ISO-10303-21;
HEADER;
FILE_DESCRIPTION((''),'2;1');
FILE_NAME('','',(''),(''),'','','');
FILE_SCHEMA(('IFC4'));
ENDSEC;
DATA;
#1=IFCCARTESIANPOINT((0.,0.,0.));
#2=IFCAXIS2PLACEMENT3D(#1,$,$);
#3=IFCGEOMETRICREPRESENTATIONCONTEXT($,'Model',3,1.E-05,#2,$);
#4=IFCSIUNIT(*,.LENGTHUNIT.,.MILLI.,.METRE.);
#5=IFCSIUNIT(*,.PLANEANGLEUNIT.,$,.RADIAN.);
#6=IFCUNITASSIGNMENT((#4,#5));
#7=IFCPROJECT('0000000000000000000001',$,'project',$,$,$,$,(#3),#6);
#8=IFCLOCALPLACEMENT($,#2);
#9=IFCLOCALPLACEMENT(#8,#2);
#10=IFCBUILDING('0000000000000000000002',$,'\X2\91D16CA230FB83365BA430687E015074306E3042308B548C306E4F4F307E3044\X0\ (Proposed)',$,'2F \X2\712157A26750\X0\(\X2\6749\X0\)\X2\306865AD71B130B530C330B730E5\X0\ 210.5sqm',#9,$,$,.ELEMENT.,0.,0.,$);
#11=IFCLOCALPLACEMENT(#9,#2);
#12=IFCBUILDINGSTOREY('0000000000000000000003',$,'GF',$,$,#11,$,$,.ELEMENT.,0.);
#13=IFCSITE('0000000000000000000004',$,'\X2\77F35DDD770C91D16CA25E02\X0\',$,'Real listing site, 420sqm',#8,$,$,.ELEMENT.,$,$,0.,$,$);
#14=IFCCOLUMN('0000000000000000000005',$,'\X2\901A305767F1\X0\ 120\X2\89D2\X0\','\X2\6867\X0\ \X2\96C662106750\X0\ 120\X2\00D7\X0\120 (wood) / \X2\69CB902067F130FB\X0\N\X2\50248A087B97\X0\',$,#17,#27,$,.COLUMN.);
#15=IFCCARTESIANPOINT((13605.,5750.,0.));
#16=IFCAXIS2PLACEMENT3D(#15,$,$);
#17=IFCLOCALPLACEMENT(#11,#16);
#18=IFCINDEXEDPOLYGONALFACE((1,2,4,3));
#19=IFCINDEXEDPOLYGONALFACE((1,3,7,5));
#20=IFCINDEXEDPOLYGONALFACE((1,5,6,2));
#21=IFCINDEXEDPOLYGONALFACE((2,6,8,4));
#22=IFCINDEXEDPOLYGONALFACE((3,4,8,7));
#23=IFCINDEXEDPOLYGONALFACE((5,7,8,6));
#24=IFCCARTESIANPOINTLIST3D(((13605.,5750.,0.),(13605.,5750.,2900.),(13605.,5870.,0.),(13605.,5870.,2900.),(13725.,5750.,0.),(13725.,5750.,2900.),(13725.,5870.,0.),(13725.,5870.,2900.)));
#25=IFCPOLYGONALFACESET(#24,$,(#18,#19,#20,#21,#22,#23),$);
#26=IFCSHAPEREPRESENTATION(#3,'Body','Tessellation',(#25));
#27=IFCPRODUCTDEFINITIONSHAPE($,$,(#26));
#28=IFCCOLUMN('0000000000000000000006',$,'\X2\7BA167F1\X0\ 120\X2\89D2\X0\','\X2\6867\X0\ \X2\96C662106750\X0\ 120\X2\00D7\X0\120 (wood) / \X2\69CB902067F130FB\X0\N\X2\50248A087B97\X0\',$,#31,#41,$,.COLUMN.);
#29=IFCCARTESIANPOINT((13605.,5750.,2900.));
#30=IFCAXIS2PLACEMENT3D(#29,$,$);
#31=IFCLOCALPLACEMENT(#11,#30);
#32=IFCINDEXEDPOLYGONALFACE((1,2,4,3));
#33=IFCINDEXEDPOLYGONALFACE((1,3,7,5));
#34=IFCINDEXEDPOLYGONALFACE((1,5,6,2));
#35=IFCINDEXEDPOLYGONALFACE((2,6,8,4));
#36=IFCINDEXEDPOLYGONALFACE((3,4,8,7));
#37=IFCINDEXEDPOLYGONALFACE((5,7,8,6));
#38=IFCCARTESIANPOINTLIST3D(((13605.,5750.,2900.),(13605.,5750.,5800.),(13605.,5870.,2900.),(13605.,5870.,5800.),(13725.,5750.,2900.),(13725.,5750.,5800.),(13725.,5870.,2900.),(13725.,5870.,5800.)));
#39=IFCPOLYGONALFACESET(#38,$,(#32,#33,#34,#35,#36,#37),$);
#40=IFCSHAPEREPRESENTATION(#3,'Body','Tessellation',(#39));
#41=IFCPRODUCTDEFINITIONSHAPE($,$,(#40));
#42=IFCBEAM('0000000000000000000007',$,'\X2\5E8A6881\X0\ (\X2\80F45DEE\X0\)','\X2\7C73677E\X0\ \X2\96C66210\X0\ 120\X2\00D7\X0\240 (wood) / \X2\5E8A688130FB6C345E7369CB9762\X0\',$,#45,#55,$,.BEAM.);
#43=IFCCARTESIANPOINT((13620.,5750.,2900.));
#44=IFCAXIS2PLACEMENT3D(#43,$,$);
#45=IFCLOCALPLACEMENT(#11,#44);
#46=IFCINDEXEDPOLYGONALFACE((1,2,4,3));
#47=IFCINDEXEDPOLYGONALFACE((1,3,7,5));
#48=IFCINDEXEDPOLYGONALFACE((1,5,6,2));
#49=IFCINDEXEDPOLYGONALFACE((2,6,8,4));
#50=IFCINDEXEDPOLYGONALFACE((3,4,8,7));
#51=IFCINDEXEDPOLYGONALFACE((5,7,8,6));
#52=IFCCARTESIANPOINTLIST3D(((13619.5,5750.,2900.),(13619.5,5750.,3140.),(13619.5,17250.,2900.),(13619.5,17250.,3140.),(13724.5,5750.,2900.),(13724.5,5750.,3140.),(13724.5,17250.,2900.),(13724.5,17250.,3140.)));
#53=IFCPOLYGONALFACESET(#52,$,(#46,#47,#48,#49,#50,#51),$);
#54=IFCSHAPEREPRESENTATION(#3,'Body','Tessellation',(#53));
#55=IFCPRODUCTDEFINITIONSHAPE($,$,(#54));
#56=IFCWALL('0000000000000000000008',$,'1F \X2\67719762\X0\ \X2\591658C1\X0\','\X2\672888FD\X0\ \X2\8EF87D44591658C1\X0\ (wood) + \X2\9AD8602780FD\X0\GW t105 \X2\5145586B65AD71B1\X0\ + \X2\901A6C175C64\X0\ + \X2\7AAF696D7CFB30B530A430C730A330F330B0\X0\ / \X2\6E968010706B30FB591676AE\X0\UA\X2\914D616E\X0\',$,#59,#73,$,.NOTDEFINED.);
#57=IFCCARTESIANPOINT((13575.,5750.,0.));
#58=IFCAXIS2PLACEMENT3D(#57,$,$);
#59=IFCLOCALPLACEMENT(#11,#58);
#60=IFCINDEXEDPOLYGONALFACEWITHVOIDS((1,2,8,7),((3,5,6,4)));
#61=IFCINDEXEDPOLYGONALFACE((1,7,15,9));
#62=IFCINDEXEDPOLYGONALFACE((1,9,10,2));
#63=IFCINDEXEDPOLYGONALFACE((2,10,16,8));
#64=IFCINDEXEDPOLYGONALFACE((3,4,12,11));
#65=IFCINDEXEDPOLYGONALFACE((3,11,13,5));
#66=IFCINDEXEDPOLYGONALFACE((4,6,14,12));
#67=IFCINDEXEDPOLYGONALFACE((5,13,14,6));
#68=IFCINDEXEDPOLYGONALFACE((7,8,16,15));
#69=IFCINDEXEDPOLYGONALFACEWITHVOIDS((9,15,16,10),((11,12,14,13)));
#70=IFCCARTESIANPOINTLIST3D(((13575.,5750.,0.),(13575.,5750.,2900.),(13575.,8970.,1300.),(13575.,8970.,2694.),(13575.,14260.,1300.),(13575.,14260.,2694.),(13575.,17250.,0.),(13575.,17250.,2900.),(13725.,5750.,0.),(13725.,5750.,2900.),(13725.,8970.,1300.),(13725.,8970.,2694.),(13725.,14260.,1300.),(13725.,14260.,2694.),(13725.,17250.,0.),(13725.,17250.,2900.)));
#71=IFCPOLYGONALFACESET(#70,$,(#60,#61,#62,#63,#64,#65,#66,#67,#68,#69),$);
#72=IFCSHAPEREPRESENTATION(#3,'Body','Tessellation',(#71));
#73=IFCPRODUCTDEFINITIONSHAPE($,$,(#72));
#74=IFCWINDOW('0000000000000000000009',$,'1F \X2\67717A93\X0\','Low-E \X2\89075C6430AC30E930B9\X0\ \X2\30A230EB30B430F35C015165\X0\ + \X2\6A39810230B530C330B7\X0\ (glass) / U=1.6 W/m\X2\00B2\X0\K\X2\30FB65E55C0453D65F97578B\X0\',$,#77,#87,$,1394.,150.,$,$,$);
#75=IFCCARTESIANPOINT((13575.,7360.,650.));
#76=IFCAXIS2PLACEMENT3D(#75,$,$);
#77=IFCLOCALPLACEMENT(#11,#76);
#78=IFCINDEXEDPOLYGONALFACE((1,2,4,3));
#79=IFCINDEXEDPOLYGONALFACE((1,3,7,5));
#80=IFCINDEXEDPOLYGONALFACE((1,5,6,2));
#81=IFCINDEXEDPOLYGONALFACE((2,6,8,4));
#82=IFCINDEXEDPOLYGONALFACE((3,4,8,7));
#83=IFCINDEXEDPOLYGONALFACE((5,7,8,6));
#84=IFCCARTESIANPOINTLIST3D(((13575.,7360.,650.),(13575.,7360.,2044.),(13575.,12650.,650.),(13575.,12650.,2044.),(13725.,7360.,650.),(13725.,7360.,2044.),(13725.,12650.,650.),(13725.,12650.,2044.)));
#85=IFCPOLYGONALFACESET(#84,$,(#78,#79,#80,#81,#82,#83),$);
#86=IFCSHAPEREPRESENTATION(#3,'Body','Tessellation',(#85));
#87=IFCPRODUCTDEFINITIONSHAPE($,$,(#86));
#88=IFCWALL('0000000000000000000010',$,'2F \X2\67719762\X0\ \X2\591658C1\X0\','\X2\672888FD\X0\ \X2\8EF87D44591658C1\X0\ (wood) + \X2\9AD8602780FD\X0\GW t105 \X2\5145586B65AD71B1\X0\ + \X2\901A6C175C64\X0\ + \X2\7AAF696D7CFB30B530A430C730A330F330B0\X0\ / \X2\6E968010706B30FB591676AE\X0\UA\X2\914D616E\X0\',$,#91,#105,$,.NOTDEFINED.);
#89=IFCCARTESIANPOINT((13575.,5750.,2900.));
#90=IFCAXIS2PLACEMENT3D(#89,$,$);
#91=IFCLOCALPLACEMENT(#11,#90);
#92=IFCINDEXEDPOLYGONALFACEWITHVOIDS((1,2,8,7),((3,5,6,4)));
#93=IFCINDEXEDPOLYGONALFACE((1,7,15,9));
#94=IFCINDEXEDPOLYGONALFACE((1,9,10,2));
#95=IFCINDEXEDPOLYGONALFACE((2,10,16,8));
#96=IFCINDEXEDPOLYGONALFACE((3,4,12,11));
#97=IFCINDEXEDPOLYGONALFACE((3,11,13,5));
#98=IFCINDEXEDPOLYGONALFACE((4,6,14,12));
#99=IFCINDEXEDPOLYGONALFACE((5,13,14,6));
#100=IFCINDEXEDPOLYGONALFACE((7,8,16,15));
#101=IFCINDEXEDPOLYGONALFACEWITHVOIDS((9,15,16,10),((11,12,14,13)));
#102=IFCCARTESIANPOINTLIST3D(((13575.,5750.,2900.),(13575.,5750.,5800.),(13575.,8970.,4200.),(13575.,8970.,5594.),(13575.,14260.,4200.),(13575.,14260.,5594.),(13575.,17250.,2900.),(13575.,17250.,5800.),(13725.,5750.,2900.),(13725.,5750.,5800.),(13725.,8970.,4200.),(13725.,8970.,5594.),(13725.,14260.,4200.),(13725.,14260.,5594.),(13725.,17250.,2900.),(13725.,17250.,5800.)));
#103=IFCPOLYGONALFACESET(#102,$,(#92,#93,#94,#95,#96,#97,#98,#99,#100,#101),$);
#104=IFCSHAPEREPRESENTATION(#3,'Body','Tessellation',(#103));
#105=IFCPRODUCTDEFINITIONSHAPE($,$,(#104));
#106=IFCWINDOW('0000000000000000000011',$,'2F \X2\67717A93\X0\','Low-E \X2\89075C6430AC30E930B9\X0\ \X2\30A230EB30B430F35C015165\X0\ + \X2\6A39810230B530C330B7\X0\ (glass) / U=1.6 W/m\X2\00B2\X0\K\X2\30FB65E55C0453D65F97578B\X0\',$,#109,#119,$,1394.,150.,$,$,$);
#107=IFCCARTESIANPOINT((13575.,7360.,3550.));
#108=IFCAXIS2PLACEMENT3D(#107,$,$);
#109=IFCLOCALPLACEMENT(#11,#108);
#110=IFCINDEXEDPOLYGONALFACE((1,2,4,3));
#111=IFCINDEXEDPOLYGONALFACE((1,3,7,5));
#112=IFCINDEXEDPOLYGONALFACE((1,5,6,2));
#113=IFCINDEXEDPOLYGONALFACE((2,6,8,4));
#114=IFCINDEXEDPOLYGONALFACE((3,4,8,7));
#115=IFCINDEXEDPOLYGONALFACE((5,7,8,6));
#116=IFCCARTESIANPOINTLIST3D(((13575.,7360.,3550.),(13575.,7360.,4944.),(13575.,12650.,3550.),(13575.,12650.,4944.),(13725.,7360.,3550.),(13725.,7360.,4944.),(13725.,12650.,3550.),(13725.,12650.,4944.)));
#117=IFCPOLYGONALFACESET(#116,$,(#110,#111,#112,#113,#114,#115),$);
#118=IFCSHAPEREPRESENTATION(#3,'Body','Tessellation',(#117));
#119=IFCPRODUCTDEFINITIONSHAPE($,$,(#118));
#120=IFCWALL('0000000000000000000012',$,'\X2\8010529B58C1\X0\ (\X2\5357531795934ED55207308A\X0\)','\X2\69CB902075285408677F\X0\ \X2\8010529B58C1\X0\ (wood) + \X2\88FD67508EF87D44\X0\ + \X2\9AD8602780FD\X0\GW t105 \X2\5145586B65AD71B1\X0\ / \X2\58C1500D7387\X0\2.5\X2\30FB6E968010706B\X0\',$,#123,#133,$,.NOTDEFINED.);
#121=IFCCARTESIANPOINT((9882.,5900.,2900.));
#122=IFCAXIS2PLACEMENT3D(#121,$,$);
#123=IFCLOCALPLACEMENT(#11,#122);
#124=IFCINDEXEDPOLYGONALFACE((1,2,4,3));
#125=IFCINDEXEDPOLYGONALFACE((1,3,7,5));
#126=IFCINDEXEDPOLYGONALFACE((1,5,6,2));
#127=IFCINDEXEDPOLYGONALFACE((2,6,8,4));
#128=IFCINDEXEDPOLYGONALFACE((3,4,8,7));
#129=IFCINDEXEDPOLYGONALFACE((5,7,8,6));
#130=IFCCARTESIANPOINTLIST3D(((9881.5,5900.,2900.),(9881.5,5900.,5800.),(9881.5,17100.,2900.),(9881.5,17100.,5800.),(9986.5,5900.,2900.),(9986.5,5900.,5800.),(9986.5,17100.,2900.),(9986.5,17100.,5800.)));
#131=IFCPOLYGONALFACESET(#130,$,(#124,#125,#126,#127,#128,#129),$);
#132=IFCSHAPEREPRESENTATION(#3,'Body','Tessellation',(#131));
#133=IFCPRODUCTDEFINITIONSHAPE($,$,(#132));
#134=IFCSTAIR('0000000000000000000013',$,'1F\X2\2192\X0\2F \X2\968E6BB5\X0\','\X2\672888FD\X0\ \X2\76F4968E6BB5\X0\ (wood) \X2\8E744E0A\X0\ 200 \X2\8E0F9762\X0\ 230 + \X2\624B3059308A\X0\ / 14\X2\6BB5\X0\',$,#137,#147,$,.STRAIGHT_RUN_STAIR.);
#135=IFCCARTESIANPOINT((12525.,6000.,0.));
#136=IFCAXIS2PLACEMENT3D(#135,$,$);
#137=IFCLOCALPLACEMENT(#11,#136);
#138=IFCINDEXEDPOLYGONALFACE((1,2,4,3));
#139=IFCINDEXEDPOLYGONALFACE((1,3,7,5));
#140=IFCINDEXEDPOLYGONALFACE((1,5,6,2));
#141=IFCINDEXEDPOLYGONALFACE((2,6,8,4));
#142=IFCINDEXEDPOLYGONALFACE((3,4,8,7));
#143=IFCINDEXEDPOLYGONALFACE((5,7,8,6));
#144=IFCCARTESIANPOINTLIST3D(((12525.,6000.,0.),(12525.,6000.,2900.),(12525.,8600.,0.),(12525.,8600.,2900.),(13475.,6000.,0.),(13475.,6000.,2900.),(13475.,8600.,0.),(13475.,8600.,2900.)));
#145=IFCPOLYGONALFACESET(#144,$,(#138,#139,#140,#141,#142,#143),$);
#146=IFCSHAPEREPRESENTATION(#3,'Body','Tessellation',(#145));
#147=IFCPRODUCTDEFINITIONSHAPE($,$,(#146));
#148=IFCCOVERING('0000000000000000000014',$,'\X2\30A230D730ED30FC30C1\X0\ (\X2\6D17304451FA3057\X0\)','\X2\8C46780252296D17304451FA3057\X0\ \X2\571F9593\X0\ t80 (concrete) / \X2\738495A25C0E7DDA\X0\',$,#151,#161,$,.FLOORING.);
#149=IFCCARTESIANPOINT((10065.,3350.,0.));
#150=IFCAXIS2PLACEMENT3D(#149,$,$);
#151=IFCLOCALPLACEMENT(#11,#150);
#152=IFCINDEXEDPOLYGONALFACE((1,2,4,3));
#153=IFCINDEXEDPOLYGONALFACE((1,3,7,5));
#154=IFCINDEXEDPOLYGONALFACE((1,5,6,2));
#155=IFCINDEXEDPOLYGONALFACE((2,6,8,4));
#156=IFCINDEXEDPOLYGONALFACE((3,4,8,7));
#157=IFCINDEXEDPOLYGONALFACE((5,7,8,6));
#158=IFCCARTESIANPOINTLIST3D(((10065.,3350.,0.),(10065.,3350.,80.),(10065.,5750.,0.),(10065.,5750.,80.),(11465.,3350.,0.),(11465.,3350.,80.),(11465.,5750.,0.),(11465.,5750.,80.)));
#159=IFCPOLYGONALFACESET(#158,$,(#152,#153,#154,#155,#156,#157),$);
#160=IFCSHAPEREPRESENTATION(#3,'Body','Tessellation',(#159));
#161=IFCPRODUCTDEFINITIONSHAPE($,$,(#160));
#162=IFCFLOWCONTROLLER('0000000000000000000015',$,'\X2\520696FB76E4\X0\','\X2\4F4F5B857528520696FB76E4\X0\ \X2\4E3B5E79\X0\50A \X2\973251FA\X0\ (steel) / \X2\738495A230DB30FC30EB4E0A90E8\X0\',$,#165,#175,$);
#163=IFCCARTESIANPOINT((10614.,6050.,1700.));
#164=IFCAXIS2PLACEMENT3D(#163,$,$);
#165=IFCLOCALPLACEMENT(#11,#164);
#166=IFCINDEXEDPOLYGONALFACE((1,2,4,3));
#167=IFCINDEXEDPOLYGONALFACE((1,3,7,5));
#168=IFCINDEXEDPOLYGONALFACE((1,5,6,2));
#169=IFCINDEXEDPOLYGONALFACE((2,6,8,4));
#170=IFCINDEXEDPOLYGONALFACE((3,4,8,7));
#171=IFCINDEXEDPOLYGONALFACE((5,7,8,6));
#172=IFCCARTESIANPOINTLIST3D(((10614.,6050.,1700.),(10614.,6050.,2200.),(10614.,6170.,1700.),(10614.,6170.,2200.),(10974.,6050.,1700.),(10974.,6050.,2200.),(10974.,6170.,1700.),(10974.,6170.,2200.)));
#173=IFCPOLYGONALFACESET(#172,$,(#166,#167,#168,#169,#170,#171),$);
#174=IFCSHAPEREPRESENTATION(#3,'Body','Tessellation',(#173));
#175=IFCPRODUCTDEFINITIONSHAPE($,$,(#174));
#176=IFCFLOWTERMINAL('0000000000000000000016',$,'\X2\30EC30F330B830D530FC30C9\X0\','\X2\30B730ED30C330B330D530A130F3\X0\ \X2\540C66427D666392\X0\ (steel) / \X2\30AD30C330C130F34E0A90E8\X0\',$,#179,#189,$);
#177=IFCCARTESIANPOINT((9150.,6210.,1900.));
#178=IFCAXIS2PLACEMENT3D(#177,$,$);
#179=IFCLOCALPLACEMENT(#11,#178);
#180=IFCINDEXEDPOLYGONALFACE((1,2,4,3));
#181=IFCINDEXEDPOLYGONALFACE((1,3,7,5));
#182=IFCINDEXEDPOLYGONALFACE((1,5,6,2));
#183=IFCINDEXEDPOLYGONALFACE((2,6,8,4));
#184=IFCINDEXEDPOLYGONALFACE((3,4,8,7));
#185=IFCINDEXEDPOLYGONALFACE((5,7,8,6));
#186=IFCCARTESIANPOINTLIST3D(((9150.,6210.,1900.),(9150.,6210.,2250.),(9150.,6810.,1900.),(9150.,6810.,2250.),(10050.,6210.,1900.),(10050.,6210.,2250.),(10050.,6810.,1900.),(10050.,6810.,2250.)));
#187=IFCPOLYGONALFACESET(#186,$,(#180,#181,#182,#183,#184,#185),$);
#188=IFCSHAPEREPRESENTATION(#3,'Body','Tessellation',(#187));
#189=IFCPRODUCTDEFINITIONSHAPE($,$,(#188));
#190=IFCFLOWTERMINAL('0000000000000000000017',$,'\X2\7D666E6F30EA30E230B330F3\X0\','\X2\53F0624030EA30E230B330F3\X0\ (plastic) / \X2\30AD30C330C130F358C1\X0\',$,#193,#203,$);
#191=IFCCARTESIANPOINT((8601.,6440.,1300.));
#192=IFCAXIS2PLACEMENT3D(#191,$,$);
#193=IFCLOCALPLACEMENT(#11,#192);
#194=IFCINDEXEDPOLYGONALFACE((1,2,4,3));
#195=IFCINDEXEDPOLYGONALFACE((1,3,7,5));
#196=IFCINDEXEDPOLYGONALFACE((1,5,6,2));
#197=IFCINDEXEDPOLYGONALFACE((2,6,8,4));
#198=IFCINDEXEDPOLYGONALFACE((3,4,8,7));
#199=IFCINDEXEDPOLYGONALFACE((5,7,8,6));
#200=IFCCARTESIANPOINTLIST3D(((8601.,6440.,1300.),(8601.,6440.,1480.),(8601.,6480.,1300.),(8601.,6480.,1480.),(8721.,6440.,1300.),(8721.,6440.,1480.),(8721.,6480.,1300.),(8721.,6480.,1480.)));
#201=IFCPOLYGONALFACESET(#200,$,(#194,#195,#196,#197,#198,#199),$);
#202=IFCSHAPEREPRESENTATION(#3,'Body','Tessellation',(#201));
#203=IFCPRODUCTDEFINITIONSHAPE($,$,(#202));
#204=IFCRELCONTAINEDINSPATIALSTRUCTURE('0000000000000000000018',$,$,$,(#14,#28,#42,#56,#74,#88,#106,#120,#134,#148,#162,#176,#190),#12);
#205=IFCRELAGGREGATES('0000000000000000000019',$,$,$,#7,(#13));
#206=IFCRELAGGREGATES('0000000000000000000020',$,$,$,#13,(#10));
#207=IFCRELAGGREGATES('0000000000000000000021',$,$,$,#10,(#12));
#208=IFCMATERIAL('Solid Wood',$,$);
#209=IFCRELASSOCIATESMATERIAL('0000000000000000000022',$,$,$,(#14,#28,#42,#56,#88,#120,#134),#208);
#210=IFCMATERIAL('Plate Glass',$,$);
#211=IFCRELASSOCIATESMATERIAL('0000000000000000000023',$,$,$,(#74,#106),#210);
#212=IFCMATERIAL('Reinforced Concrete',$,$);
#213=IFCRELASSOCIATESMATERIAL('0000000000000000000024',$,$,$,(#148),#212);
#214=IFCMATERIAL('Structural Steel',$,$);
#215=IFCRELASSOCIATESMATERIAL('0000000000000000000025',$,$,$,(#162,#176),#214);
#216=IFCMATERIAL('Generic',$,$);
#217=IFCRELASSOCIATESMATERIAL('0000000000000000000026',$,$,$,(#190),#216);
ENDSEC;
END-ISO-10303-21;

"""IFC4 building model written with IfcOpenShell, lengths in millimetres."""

from ifc_helpers import new_model, si_unit, frame, frame_2d, origin, place, context, project, spatial, rectangle, extrude, material, element, fill, save


model = new_model("IFC4")

# Units and contexts
model_context = context("Model", 3, precision=1e-05, world=origin())
ifc_project = project(units=[si_unit("LENGTHUNIT", "METRE", prefix="MILLI"), si_unit("PLANEANGLEUNIT", "RADIAN")], contexts=[model_context])

# Site, building, storey
site_placement = place(None, origin())
site = spatial("IfcSite", under=ifc_project, at=site_placement, Name="石川県金沢市", ObjectType="Real listing site, 420sqm", CompositionType="ELEMENT", RefElevation=0.0)
building_placement = place(site_placement, origin())
building = spatial("IfcBuilding", under=site, at=building_placement, Name="金沢・茶室と縁側のある和の住まい (Proposed)", ObjectType="2F 無垢材(杉)と断熱サッシュ 210.5sqm", CompositionType="ELEMENT", ElevationOfRefHeight=0.0, ElevationOfTerrain=0.0)
storey_placement = place(building_placement, origin())
storey = spatial("IfcBuildingStorey", under=building, at=storey_placement, Name="GF", CompositionType="ELEMENT", Elevation=0.0)

# Columns
ifc_material_1 = material(Name="Solid Wood")
column_1_placement = place(storey_placement, frame((13605.0, 5750.0, 0.0)))
element("IfcColumn", 1, at=column_1_placement, inside=storey, material=ifc_material_1, Name="通し柱 120角", Description="桧 集成材 120×120 (wood) / 構造柱・N値計算", PredefinedType="COLUMN", context=model_context, shape_type="SweptSolid", body=[
    extrude(rectangle(XDim=120.0, YDim=120.0, at=frame_2d((60.0, 60.0))), frame((13605.0, 5750.0, 0.0)), (0.0, 0.0, 1.0), 2900.0),
])
column_2_placement = place(storey_placement, frame((13605.0, 5750.0, 2900.0)))
element("IfcColumn", 2, at=column_2_placement, inside=storey, material=ifc_material_1, Name="管柱 120角", Description="桧 集成材 120×120 (wood) / 構造柱・N値計算", PredefinedType="COLUMN", context=model_context, shape_type="SweptSolid", body=[
    extrude(rectangle(XDim=120.0, YDim=120.0, at=frame_2d((60.0, 60.0))), frame((13605.0, 5750.0, 2900.0)), (0.0, 0.0, 1.0), 2900.0),
])

# Beam
beam_1_placement = place(storey_placement, frame((13620.0, 5750.0, 2900.0)))
element("IfcBeam", 3, at=beam_1_placement, inside=storey, material=ifc_material_1, Name="床梁 (胴差)", Description="米松 集成 120×240 (wood) / 床梁・水平構面", PredefinedType="BEAM", context=model_context, shape_type="SweptSolid", body=[
    extrude(rectangle(XDim=105.0, YDim=11500.0, at=frame_2d((52.0, 5750.0))), frame((13620.0, 5750.0, 2900.0)), (0.0, 0.0, 1.0), 240.0),
])

# Wall, opening, window
wall_1_placement = place(storey_placement, frame((13575.0, 5750.0, 0.0)))
wall_1 = element("IfcWall", 4, at=wall_1_placement, inside=storey, material=ifc_material_1, Name="1F 東面 外壁", Description="木製 軸組外壁 (wood) + 高性能GW t105 充填断熱 + 通気層 + 窯業系サイディング / 準耐火・外皮UA配慮", PredefinedType="NOTDEFINED", context=model_context, shape_type="SweptSolid", body=[
    extrude(rectangle(XDim=150.0, YDim=11500.0, at=frame_2d((75.0, 5750.0))), frame((13575.0, 5750.0, 0.0)), (0.0, 0.0, 1.0), 2900.0),
])
opening_1_placement = place(storey_placement, frame((13575.0, 7360.0, 650.0)))
opening_1 = element("IfcOpeningElement", 5, at=opening_1_placement, cuts=wall_1, PredefinedType="NOTDEFINED", context=model_context, shape_type="SweptSolid", body=[
    extrude(rectangle(XDim=150.0, YDim=5290.0, at=frame_2d((75.0, 2645.0))), frame((13575.0, 7360.0, 650.0)), (0.0, 0.0, 1.0), 1394.0),
])
ifc_material_2 = material(Name="Plate Glass")
window_1_placement = place(storey_placement, frame((13575.0, 7360.0, 650.0)))
window_1 = element("IfcWindow", 6, at=window_1_placement, inside=storey, material=ifc_material_2, Name="1F 東窓", Description="Low-E 複層ガラス アルゴン封入 + 樹脂サッシ (glass) / U=1.6 W/m²K・日射取得型", OverallHeight=1394.0, OverallWidth=150.0, context=model_context, shape_type="SweptSolid", body=[
    extrude(rectangle(XDim=150.0, YDim=5290.0, at=frame_2d((75.0, 2645.0))), frame((13575.0, 7360.0, 650.0)), (0.0, 0.0, 1.0), 1394.0),
])
fill(opening_1, window_1)

# Wall, opening, window
wall_2_placement = place(storey_placement, frame((13575.0, 5750.0, 2900.0)))
wall_2 = element("IfcWall", 7, at=wall_2_placement, inside=storey, material=ifc_material_1, Name="2F 東面 外壁", Description="木製 軸組外壁 (wood) + 高性能GW t105 充填断熱 + 通気層 + 窯業系サイディング / 準耐火・外皮UA配慮", PredefinedType="NOTDEFINED", context=model_context, shape_type="SweptSolid", body=[
    extrude(rectangle(XDim=150.0, YDim=11500.0, at=frame_2d((75.0, 5750.0))), frame((13575.0, 5750.0, 2900.0)), (0.0, 0.0, 1.0), 2900.0),
])
opening_2_placement = place(storey_placement, frame((13575.0, 7360.0, 3550.0)))
opening_2 = element("IfcOpeningElement", 8, at=opening_2_placement, cuts=wall_2, PredefinedType="NOTDEFINED", context=model_context, shape_type="SweptSolid", body=[
    extrude(rectangle(XDim=150.0, YDim=5290.0, at=frame_2d((75.0, 2645.0))), frame((13575.0, 7360.0, 3550.0)), (0.0, 0.0, 1.0), 1394.0),
])
window_2_placement = place(storey_placement, frame((13575.0, 7360.0, 3550.0)))
window_2 = element("IfcWindow", 9, at=window_2_placement, inside=storey, material=ifc_material_2, Name="2F 東窓", Description="Low-E 複層ガラス アルゴン封入 + 樹脂サッシ (glass) / U=1.6 W/m²K・日射取得型", OverallHeight=1394.0, OverallWidth=150.0, context=model_context, shape_type="SweptSolid", body=[
    extrude(rectangle(XDim=150.0, YDim=5290.0, at=frame_2d((75.0, 2645.0))), frame((13575.0, 7360.0, 3550.0)), (0.0, 0.0, 1.0), 1394.0),
])
fill(opening_2, window_2)

# Wall
wall_3_placement = place(storey_placement, frame((9882.0, 5900.0, 2900.0)))
element("IfcWall", 10, at=wall_3_placement, inside=storey, material=ifc_material_1, Name="耐力壁 (南北間仕切り)", Description="構造用合板 耐力壁 (wood) + 製材軸組 + 高性能GW t105 充填断熱 / 壁倍率2.5・準耐火", PredefinedType="NOTDEFINED", context=model_context, shape_type="SweptSolid", body=[
    extrude(rectangle(XDim=105.0, YDim=11200.0, at=frame_2d((52.0, 5600.0))), frame((9882.0, 5900.0, 2900.0)), (0.0, 0.0, 1.0), 2900.0),
])

# Stair
stair_placement = place(storey_placement, frame((12525.0, 6000.0, 0.0)))
element("IfcStair", 11, at=stair_placement, inside=storey, material=ifc_material_1, Name="1F→2F 階段", Description="木製 直階段 (wood) 蹴上 200 踏面 230 + 手すり / 14段", PredefinedType="STRAIGHT_RUN_STAIR", context=model_context, shape_type="SweptSolid", body=[
    extrude(rectangle(XDim=950.0, YDim=2600.0, at=frame_2d((475.0, 1300.0))), frame((12525.0, 6000.0, 0.0)), (0.0, 0.0, 1.0), 2900.0),
])

# Covering
ifc_material_3 = material(Name="Reinforced Concrete")
covering_placement = place(storey_placement, frame((10065.0, 3350.0, 0.0)))
element("IfcCovering", 12, at=covering_placement, inside=storey, material=ifc_material_3, Name="アプローチ (洗い出し)", Description="豆砂利洗い出し 土間 t80 (concrete) / 玄関導線", PredefinedType="FLOORING", context=model_context, shape_type="SweptSolid", body=[
    extrude(rectangle(XDim=1400.0, YDim=2400.0, at=frame_2d((700.0, 1200.0))), frame((10065.0, 3350.0, 0.0)), (0.0, 0.0, 1.0), 80.0),
])

# Flow controller
ifc_material_4 = material(Name="Structural Steel")
flow_controller_placement = place(storey_placement, frame((10614.0, 6050.0, 1700.0)))
element("IfcFlowController", 13, at=flow_controller_placement, inside=storey, material=ifc_material_4, Name="分電盤", Description="住宅用分電盤 主幹50A 露出 (steel) / 玄関ホール上部", context=model_context, shape_type="SweptSolid", body=[
    extrude(rectangle(XDim=360.0, YDim=120.0, at=frame_2d((180.0, 60.0))), frame((10614.0, 6050.0, 1700.0)), (0.0, 0.0, 1.0), 500.0),
])

# Flow terminals
flow_terminal_1_placement = place(storey_placement, frame((9150.0, 6210.0, 1900.0)))
element("IfcFlowTerminal", 14, at=flow_terminal_1_placement, inside=storey, material=ifc_material_4, Name="レンジフード", Description="シロッコファン 同時給排 (steel) / キッチン上部", context=model_context, shape_type="SweptSolid", body=[
    extrude(rectangle(XDim=900.0, YDim=600.0, at=frame_2d((450.0, 300.0))), frame((9150.0, 6210.0, 1900.0)), (0.0, 0.0, 1.0), 350.0),
])
ifc_material_5 = material(Name="Generic")
flow_terminal_2_placement = place(storey_placement, frame((8601.0, 6440.0, 1300.0)))
element("IfcFlowTerminal", 15, at=flow_terminal_2_placement, inside=storey, material=ifc_material_5, Name="給湯リモコン", Description="台所リモコン (plastic) / キッチン壁", context=model_context, shape_type="SweptSolid", body=[
    extrude(rectangle(XDim=120.0, YDim=40.0, at=frame_2d((60.0, 20.0))), frame((8601.0, 6440.0, 1300.0)), (0.0, 0.0, 1.0), 180.0),
])

save(model, "model.ifc")
